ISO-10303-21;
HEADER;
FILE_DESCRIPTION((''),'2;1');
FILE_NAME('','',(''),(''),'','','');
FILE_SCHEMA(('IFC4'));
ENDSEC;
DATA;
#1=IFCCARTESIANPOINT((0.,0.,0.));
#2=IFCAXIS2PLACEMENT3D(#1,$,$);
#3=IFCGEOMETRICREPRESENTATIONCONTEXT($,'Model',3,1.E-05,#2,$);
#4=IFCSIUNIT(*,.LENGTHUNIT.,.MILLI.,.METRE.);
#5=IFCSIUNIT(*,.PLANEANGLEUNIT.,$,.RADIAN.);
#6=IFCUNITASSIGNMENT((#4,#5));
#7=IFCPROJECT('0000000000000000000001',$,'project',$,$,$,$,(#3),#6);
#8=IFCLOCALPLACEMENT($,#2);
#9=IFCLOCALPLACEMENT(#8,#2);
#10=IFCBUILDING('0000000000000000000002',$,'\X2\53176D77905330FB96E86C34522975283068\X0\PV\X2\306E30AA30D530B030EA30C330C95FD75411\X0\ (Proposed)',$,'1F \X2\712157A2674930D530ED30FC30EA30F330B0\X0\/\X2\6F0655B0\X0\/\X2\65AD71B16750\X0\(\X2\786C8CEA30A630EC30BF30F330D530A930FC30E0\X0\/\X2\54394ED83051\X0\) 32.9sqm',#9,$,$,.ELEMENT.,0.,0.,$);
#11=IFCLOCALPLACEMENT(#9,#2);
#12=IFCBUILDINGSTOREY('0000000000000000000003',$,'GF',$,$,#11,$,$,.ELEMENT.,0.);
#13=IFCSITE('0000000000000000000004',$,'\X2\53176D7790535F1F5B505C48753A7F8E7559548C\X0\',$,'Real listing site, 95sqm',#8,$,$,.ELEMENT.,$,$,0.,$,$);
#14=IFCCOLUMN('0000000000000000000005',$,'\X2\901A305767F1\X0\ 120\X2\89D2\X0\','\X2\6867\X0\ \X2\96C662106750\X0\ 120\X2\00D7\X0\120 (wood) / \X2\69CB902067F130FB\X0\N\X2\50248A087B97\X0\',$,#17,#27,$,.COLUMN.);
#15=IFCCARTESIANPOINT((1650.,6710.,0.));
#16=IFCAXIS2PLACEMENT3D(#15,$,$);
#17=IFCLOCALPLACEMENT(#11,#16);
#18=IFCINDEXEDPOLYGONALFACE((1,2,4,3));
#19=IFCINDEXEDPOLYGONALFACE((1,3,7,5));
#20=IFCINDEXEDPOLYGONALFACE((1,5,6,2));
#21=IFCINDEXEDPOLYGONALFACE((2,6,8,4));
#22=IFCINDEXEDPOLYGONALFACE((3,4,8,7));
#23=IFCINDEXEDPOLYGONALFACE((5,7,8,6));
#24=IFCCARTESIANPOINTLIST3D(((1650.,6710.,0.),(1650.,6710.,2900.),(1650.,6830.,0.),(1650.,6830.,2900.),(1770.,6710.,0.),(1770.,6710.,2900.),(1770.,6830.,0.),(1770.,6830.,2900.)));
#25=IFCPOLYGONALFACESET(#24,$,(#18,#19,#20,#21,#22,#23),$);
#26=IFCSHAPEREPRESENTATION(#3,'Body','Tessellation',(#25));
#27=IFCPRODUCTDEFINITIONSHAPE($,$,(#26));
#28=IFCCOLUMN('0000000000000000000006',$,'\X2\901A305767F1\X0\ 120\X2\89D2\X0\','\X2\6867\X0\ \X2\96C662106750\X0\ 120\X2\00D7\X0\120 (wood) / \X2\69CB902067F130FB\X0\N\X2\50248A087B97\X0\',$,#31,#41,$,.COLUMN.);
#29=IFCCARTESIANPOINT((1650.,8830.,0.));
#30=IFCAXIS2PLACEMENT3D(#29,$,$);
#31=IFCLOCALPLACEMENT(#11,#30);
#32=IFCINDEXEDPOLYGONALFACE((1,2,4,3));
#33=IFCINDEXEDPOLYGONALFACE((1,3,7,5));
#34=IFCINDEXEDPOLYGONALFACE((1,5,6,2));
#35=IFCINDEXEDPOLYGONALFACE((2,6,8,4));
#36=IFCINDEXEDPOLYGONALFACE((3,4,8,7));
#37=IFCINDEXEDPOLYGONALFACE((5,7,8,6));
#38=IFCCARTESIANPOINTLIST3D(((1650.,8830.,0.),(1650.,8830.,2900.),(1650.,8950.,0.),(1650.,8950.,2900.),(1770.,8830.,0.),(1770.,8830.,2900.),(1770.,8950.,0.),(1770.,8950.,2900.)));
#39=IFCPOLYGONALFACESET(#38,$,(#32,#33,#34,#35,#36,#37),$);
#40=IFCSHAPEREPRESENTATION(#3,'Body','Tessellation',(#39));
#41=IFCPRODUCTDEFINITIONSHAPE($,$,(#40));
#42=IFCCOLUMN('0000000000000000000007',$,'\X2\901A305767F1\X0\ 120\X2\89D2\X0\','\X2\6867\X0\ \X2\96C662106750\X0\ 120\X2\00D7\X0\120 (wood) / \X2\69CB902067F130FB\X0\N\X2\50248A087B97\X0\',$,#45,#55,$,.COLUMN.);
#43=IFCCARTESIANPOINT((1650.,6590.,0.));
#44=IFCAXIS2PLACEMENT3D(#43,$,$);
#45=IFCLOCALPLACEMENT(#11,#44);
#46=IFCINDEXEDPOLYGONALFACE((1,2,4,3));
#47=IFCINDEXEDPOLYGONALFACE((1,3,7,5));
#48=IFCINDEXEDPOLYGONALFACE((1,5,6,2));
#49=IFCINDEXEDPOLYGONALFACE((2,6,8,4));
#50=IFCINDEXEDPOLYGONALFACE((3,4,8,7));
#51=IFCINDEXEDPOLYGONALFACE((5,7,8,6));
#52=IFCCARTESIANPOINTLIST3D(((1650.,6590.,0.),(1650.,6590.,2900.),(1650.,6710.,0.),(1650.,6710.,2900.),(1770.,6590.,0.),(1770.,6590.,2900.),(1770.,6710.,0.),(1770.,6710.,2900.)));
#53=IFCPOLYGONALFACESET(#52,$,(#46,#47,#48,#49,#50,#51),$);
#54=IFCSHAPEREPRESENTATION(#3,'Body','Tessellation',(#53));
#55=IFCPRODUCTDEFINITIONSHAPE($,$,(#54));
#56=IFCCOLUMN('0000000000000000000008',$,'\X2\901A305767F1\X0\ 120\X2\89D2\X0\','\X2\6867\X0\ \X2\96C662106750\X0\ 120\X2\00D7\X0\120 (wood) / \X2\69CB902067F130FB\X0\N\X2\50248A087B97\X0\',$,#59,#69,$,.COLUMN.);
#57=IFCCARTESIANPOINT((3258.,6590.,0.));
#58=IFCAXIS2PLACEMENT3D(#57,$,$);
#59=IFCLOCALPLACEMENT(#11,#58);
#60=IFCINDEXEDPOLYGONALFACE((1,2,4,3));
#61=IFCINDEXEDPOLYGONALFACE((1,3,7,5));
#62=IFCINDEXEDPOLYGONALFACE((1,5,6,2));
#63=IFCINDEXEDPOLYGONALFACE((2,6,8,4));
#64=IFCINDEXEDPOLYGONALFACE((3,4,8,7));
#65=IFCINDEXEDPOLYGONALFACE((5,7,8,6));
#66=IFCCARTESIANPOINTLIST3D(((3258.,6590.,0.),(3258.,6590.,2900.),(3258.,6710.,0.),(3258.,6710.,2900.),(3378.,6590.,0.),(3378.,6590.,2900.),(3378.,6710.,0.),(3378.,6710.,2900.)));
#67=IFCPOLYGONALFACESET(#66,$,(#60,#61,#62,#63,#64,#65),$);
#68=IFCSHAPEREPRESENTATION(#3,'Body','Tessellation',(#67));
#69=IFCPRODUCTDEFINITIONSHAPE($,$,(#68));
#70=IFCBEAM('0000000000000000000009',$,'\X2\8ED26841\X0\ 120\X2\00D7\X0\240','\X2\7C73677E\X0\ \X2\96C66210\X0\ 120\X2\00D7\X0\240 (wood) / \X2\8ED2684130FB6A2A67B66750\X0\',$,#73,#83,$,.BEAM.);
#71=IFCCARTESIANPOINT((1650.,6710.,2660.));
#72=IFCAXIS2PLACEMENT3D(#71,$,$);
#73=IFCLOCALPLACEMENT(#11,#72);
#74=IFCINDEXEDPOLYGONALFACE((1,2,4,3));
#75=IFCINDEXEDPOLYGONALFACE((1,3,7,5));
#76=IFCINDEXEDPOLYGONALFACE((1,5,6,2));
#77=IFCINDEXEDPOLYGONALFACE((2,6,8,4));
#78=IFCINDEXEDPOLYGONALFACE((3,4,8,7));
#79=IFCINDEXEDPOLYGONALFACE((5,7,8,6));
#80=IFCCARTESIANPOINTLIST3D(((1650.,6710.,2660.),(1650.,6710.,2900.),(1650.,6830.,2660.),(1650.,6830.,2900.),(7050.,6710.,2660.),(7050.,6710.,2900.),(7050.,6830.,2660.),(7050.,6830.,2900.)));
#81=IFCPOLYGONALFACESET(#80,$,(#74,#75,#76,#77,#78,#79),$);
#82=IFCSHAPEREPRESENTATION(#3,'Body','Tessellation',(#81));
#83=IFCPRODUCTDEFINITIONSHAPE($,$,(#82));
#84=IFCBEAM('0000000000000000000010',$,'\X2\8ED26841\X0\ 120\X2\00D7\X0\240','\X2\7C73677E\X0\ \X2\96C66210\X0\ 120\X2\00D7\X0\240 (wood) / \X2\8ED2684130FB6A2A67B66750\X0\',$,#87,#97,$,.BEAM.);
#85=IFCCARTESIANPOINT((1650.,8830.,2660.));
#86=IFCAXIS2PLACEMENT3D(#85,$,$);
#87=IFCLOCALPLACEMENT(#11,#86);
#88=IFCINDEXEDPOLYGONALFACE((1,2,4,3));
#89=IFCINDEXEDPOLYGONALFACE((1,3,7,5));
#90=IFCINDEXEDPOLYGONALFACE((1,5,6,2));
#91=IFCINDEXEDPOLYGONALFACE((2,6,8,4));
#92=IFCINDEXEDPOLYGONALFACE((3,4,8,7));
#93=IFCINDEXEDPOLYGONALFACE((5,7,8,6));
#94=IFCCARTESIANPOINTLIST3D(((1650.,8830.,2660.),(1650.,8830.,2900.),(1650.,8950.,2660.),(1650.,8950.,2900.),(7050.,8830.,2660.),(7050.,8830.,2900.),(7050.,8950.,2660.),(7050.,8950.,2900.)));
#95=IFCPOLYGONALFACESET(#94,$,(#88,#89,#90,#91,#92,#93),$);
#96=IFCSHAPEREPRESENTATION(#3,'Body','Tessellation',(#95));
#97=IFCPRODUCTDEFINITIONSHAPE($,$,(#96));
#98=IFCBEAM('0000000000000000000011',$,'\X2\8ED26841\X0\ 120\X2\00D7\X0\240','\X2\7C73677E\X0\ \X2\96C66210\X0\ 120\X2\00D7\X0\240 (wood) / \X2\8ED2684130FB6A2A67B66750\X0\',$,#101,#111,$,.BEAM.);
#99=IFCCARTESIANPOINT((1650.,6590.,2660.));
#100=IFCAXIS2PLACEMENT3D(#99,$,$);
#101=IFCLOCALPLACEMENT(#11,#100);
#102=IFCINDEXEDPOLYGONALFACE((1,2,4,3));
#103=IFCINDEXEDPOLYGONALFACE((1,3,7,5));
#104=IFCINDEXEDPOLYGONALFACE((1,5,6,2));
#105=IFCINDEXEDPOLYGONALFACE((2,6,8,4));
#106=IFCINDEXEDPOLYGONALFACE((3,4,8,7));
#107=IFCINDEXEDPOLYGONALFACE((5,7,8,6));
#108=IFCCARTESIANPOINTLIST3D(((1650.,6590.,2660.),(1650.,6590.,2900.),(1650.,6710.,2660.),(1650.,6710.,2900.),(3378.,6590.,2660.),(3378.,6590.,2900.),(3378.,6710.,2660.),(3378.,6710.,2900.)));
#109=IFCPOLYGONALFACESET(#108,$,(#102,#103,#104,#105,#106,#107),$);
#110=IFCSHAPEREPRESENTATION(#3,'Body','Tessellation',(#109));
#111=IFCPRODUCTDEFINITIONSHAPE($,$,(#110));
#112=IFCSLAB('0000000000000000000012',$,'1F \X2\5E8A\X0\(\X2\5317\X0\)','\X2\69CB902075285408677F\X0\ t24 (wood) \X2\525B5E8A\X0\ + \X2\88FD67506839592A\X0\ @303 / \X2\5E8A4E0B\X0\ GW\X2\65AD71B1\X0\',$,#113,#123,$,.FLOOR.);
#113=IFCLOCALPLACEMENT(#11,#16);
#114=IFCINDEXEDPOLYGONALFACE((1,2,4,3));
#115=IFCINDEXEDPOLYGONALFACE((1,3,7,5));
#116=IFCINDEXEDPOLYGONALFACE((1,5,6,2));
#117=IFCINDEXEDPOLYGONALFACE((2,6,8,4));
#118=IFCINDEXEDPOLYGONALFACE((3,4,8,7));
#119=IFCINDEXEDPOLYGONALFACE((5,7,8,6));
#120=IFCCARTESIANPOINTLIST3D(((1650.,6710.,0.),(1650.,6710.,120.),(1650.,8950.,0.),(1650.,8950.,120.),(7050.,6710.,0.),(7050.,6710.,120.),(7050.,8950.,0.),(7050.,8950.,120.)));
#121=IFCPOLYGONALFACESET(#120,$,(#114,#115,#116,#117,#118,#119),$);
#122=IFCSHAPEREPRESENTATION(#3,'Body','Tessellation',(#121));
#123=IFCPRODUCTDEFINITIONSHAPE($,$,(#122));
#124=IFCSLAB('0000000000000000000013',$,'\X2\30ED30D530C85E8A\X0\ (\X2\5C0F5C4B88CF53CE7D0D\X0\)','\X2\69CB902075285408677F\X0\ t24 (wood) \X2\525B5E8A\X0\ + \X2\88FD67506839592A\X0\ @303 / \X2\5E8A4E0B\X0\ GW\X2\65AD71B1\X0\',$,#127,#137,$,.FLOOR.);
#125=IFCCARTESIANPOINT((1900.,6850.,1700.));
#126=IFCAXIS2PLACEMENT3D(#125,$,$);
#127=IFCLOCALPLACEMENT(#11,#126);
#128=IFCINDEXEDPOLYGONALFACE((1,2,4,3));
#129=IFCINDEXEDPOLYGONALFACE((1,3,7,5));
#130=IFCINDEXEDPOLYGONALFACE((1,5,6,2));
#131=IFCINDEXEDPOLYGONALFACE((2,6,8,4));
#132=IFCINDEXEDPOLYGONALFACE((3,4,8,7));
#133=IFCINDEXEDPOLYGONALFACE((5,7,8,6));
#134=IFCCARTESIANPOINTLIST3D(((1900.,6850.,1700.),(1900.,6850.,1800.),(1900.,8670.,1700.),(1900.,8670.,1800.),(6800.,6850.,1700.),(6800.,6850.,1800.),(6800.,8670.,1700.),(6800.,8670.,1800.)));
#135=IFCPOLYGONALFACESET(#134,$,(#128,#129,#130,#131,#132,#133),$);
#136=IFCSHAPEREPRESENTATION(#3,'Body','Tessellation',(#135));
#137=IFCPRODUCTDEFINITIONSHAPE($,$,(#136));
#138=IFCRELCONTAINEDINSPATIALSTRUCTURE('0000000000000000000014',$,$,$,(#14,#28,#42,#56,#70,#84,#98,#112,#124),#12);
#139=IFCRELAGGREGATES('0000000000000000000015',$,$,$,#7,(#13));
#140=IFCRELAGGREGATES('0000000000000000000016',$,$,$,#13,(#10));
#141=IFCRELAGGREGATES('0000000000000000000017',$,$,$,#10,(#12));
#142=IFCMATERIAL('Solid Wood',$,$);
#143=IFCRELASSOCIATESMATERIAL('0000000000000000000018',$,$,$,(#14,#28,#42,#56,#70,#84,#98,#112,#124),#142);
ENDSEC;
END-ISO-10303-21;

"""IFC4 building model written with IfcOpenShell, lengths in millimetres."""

from ifc_helpers import new_model, si_unit, frame, frame_2d, origin, place, context, project, spatial, rectangle, extrude, material, element, save


model = new_model("IFC4")

# Units and contexts
model_context = context("Model", 3, precision=1e-05, world=origin())
ifc_project = project(units=[si_unit("LENGTHUNIT", "METRE", prefix="MILLI"), si_unit("PLANEANGLEUNIT", "RADIAN")], contexts=[model_context])

# Site, building, storey
site_placement = place(None, origin())
site = spatial("IfcSite", under=ifc_project, at=site_placement, Name="北海道弟子屈町美留和", ObjectType="Real listing site, 95sqm", CompositionType="ELEMENT", RefElevation=0.0)
building_placement = place(site_placement, origin())
building = spatial("IfcBuilding", under=site, at=building_placement, Name="北海道・雨水利用とPVのオフグリッド志向 (Proposed)", ObjectType="1F 無垢杉フローリング/漆喰/断熱材(硬質ウレタンフォーム/吹付け) 32.9sqm", CompositionType="ELEMENT", ElevationOfRefHeight=0.0, ElevationOfTerrain=0.0)
storey_placement = place(building_placement, origin())
storey = spatial("IfcBuildingStorey", under=building, at=storey_placement, Name="GF", CompositionType="ELEMENT", Elevation=0.0)

# Columns
ifc_material_1 = material(Name="Solid Wood")
column_1_placement = place(storey_placement, frame((1650.0, 6710.0, 0.0)))
element("IfcColumn", 1, at=column_1_placement, inside=storey, material=ifc_material_1, Name="通し柱 120角", Description="桧 集成材 120×120 (wood) / 構造柱・N値計算", PredefinedType="COLUMN", context=model_context, shape_type="SweptSolid", body=[
    extrude(rectangle(XDim=120.0, YDim=120.0, at=frame_2d((60.0, 60.0))), frame((1650.0, 6710.0, 0.0)), (0.0, 0.0, 1.0), 2900.0),
])
column_2_placement = place(storey_placement, frame((1650.0, 8830.0, 0.0)))
element("IfcColumn", 2, at=column_2_placement, inside=storey, material=ifc_material_1, Name="通し柱 120角", Description="桧 集成材 120×120 (wood) / 構造柱・N値計算", PredefinedType="COLUMN", context=model_context, shape_type="SweptSolid", body=[
    extrude(rectangle(XDim=120.0, YDim=120.0, at=frame_2d((60.0, 60.0))), frame((1650.0, 8830.0, 0.0)), (0.0, 0.0, 1.0), 2900.0),
])
column_3_placement = place(storey_placement, frame((1650.0, 6590.0, 0.0)))
element("IfcColumn", 3, at=column_3_placement, inside=storey, material=ifc_material_1, Name="通し柱 120角", Description="桧 集成材 120×120 (wood) / 構造柱・N値計算", PredefinedType="COLUMN", context=model_context, shape_type="SweptSolid", body=[
    extrude(rectangle(XDim=120.0, YDim=120.0, at=frame_2d((60.0, 60.0))), frame((1650.0, 6590.0, 0.0)), (0.0, 0.0, 1.0), 2900.0),
])
column_4_placement = place(storey_placement, frame((3258.0, 6590.0, 0.0)))
element("IfcColumn", 4, at=column_4_placement, inside=storey, material=ifc_material_1, Name="通し柱 120角", Description="桧 集成材 120×120 (wood) / 構造柱・N値計算", PredefinedType="COLUMN", context=model_context, shape_type="SweptSolid", body=[
    extrude(rectangle(XDim=120.0, YDim=120.0, at=frame_2d((60.0, 60.0))), frame((3258.0, 6590.0, 0.0)), (0.0, 0.0, 1.0), 2900.0),
])

# Beams
beam_1_placement = place(storey_placement, frame((1650.0, 6710.0, 2660.0)))
element("IfcBeam", 5, at=beam_1_placement, inside=storey, material=ifc_material_1, Name="軒桁 120×240", Description="米松 集成 120×240 (wood) / 軒桁・横架材", PredefinedType="BEAM", context=model_context, shape_type="SweptSolid", body=[
    extrude(rectangle(XDim=5400.0, YDim=120.0, at=frame_2d((2700.0, 60.0))), frame((1650.0, 6710.0, 2660.0)), (0.0, 0.0, 1.0), 240.0),
])
beam_2_placement = place(storey_placement, frame((1650.0, 8830.0, 2660.0)))
element("IfcBeam", 6, at=beam_2_placement, inside=storey, material=ifc_material_1, Name="軒桁 120×240", Description="米松 集成 120×240 (wood) / 軒桁・横架材", PredefinedType="BEAM", context=model_context, shape_type="SweptSolid", body=[
    extrude(rectangle(XDim=5400.0, YDim=120.0, at=frame_2d((2700.0, 60.0))), frame((1650.0, 8830.0, 2660.0)), (0.0, 0.0, 1.0), 240.0),
])
beam_3_placement = place(storey_placement, frame((1650.0, 6590.0, 2660.0)))
element("IfcBeam", 7, at=beam_3_placement, inside=storey, material=ifc_material_1, Name="軒桁 120×240", Description="米松 集成 120×240 (wood) / 軒桁・横架材", PredefinedType="BEAM", context=model_context, shape_type="SweptSolid", body=[
    extrude(rectangle(XDim=1728.0, YDim=120.0, at=frame_2d((864.0, 60.0))), frame((1650.0, 6590.0, 2660.0)), (0.0, 0.0, 1.0), 240.0),
])

# Slabs
slab_1_placement = place(storey_placement, frame((1650.0, 6710.0, 0.0)))
element("IfcSlab", 8, at=slab_1_placement, inside=storey, material=ifc_material_1, Name="1F 床(北)", Description="構造用合板 t24 (wood) 剛床 + 製材根太 @303 / 床下 GW断熱", PredefinedType="FLOOR", context=model_context, shape_type="SweptSolid", body=[
    extrude(rectangle(XDim=5400.0, YDim=2240.0, at=frame_2d((2700.0, 1120.0))), frame((1650.0, 6710.0, 0.0)), (0.0, 0.0, 1.0), 120.0),
])
slab_2_placement = place(storey_placement, frame((1900.0, 6850.0, 1700.0)))
element("IfcSlab", 9, at=slab_2_placement, inside=storey, material=ifc_material_1, Name="ロフト床 (小屋裏収納)", Description="構造用合板 t24 (wood) 剛床 + 製材根太 @303 / 床下 GW断熱", PredefinedType="FLOOR", context=model_context, shape_type="SweptSolid", body=[
    extrude(rectangle(XDim=4900.0, YDim=1820.0, at=frame_2d((2450.0, 910.0))), frame((1900.0, 6850.0, 1700.0)), (0.0, 0.0, 1.0), 100.0),
])

save(model, "model.ifc")
